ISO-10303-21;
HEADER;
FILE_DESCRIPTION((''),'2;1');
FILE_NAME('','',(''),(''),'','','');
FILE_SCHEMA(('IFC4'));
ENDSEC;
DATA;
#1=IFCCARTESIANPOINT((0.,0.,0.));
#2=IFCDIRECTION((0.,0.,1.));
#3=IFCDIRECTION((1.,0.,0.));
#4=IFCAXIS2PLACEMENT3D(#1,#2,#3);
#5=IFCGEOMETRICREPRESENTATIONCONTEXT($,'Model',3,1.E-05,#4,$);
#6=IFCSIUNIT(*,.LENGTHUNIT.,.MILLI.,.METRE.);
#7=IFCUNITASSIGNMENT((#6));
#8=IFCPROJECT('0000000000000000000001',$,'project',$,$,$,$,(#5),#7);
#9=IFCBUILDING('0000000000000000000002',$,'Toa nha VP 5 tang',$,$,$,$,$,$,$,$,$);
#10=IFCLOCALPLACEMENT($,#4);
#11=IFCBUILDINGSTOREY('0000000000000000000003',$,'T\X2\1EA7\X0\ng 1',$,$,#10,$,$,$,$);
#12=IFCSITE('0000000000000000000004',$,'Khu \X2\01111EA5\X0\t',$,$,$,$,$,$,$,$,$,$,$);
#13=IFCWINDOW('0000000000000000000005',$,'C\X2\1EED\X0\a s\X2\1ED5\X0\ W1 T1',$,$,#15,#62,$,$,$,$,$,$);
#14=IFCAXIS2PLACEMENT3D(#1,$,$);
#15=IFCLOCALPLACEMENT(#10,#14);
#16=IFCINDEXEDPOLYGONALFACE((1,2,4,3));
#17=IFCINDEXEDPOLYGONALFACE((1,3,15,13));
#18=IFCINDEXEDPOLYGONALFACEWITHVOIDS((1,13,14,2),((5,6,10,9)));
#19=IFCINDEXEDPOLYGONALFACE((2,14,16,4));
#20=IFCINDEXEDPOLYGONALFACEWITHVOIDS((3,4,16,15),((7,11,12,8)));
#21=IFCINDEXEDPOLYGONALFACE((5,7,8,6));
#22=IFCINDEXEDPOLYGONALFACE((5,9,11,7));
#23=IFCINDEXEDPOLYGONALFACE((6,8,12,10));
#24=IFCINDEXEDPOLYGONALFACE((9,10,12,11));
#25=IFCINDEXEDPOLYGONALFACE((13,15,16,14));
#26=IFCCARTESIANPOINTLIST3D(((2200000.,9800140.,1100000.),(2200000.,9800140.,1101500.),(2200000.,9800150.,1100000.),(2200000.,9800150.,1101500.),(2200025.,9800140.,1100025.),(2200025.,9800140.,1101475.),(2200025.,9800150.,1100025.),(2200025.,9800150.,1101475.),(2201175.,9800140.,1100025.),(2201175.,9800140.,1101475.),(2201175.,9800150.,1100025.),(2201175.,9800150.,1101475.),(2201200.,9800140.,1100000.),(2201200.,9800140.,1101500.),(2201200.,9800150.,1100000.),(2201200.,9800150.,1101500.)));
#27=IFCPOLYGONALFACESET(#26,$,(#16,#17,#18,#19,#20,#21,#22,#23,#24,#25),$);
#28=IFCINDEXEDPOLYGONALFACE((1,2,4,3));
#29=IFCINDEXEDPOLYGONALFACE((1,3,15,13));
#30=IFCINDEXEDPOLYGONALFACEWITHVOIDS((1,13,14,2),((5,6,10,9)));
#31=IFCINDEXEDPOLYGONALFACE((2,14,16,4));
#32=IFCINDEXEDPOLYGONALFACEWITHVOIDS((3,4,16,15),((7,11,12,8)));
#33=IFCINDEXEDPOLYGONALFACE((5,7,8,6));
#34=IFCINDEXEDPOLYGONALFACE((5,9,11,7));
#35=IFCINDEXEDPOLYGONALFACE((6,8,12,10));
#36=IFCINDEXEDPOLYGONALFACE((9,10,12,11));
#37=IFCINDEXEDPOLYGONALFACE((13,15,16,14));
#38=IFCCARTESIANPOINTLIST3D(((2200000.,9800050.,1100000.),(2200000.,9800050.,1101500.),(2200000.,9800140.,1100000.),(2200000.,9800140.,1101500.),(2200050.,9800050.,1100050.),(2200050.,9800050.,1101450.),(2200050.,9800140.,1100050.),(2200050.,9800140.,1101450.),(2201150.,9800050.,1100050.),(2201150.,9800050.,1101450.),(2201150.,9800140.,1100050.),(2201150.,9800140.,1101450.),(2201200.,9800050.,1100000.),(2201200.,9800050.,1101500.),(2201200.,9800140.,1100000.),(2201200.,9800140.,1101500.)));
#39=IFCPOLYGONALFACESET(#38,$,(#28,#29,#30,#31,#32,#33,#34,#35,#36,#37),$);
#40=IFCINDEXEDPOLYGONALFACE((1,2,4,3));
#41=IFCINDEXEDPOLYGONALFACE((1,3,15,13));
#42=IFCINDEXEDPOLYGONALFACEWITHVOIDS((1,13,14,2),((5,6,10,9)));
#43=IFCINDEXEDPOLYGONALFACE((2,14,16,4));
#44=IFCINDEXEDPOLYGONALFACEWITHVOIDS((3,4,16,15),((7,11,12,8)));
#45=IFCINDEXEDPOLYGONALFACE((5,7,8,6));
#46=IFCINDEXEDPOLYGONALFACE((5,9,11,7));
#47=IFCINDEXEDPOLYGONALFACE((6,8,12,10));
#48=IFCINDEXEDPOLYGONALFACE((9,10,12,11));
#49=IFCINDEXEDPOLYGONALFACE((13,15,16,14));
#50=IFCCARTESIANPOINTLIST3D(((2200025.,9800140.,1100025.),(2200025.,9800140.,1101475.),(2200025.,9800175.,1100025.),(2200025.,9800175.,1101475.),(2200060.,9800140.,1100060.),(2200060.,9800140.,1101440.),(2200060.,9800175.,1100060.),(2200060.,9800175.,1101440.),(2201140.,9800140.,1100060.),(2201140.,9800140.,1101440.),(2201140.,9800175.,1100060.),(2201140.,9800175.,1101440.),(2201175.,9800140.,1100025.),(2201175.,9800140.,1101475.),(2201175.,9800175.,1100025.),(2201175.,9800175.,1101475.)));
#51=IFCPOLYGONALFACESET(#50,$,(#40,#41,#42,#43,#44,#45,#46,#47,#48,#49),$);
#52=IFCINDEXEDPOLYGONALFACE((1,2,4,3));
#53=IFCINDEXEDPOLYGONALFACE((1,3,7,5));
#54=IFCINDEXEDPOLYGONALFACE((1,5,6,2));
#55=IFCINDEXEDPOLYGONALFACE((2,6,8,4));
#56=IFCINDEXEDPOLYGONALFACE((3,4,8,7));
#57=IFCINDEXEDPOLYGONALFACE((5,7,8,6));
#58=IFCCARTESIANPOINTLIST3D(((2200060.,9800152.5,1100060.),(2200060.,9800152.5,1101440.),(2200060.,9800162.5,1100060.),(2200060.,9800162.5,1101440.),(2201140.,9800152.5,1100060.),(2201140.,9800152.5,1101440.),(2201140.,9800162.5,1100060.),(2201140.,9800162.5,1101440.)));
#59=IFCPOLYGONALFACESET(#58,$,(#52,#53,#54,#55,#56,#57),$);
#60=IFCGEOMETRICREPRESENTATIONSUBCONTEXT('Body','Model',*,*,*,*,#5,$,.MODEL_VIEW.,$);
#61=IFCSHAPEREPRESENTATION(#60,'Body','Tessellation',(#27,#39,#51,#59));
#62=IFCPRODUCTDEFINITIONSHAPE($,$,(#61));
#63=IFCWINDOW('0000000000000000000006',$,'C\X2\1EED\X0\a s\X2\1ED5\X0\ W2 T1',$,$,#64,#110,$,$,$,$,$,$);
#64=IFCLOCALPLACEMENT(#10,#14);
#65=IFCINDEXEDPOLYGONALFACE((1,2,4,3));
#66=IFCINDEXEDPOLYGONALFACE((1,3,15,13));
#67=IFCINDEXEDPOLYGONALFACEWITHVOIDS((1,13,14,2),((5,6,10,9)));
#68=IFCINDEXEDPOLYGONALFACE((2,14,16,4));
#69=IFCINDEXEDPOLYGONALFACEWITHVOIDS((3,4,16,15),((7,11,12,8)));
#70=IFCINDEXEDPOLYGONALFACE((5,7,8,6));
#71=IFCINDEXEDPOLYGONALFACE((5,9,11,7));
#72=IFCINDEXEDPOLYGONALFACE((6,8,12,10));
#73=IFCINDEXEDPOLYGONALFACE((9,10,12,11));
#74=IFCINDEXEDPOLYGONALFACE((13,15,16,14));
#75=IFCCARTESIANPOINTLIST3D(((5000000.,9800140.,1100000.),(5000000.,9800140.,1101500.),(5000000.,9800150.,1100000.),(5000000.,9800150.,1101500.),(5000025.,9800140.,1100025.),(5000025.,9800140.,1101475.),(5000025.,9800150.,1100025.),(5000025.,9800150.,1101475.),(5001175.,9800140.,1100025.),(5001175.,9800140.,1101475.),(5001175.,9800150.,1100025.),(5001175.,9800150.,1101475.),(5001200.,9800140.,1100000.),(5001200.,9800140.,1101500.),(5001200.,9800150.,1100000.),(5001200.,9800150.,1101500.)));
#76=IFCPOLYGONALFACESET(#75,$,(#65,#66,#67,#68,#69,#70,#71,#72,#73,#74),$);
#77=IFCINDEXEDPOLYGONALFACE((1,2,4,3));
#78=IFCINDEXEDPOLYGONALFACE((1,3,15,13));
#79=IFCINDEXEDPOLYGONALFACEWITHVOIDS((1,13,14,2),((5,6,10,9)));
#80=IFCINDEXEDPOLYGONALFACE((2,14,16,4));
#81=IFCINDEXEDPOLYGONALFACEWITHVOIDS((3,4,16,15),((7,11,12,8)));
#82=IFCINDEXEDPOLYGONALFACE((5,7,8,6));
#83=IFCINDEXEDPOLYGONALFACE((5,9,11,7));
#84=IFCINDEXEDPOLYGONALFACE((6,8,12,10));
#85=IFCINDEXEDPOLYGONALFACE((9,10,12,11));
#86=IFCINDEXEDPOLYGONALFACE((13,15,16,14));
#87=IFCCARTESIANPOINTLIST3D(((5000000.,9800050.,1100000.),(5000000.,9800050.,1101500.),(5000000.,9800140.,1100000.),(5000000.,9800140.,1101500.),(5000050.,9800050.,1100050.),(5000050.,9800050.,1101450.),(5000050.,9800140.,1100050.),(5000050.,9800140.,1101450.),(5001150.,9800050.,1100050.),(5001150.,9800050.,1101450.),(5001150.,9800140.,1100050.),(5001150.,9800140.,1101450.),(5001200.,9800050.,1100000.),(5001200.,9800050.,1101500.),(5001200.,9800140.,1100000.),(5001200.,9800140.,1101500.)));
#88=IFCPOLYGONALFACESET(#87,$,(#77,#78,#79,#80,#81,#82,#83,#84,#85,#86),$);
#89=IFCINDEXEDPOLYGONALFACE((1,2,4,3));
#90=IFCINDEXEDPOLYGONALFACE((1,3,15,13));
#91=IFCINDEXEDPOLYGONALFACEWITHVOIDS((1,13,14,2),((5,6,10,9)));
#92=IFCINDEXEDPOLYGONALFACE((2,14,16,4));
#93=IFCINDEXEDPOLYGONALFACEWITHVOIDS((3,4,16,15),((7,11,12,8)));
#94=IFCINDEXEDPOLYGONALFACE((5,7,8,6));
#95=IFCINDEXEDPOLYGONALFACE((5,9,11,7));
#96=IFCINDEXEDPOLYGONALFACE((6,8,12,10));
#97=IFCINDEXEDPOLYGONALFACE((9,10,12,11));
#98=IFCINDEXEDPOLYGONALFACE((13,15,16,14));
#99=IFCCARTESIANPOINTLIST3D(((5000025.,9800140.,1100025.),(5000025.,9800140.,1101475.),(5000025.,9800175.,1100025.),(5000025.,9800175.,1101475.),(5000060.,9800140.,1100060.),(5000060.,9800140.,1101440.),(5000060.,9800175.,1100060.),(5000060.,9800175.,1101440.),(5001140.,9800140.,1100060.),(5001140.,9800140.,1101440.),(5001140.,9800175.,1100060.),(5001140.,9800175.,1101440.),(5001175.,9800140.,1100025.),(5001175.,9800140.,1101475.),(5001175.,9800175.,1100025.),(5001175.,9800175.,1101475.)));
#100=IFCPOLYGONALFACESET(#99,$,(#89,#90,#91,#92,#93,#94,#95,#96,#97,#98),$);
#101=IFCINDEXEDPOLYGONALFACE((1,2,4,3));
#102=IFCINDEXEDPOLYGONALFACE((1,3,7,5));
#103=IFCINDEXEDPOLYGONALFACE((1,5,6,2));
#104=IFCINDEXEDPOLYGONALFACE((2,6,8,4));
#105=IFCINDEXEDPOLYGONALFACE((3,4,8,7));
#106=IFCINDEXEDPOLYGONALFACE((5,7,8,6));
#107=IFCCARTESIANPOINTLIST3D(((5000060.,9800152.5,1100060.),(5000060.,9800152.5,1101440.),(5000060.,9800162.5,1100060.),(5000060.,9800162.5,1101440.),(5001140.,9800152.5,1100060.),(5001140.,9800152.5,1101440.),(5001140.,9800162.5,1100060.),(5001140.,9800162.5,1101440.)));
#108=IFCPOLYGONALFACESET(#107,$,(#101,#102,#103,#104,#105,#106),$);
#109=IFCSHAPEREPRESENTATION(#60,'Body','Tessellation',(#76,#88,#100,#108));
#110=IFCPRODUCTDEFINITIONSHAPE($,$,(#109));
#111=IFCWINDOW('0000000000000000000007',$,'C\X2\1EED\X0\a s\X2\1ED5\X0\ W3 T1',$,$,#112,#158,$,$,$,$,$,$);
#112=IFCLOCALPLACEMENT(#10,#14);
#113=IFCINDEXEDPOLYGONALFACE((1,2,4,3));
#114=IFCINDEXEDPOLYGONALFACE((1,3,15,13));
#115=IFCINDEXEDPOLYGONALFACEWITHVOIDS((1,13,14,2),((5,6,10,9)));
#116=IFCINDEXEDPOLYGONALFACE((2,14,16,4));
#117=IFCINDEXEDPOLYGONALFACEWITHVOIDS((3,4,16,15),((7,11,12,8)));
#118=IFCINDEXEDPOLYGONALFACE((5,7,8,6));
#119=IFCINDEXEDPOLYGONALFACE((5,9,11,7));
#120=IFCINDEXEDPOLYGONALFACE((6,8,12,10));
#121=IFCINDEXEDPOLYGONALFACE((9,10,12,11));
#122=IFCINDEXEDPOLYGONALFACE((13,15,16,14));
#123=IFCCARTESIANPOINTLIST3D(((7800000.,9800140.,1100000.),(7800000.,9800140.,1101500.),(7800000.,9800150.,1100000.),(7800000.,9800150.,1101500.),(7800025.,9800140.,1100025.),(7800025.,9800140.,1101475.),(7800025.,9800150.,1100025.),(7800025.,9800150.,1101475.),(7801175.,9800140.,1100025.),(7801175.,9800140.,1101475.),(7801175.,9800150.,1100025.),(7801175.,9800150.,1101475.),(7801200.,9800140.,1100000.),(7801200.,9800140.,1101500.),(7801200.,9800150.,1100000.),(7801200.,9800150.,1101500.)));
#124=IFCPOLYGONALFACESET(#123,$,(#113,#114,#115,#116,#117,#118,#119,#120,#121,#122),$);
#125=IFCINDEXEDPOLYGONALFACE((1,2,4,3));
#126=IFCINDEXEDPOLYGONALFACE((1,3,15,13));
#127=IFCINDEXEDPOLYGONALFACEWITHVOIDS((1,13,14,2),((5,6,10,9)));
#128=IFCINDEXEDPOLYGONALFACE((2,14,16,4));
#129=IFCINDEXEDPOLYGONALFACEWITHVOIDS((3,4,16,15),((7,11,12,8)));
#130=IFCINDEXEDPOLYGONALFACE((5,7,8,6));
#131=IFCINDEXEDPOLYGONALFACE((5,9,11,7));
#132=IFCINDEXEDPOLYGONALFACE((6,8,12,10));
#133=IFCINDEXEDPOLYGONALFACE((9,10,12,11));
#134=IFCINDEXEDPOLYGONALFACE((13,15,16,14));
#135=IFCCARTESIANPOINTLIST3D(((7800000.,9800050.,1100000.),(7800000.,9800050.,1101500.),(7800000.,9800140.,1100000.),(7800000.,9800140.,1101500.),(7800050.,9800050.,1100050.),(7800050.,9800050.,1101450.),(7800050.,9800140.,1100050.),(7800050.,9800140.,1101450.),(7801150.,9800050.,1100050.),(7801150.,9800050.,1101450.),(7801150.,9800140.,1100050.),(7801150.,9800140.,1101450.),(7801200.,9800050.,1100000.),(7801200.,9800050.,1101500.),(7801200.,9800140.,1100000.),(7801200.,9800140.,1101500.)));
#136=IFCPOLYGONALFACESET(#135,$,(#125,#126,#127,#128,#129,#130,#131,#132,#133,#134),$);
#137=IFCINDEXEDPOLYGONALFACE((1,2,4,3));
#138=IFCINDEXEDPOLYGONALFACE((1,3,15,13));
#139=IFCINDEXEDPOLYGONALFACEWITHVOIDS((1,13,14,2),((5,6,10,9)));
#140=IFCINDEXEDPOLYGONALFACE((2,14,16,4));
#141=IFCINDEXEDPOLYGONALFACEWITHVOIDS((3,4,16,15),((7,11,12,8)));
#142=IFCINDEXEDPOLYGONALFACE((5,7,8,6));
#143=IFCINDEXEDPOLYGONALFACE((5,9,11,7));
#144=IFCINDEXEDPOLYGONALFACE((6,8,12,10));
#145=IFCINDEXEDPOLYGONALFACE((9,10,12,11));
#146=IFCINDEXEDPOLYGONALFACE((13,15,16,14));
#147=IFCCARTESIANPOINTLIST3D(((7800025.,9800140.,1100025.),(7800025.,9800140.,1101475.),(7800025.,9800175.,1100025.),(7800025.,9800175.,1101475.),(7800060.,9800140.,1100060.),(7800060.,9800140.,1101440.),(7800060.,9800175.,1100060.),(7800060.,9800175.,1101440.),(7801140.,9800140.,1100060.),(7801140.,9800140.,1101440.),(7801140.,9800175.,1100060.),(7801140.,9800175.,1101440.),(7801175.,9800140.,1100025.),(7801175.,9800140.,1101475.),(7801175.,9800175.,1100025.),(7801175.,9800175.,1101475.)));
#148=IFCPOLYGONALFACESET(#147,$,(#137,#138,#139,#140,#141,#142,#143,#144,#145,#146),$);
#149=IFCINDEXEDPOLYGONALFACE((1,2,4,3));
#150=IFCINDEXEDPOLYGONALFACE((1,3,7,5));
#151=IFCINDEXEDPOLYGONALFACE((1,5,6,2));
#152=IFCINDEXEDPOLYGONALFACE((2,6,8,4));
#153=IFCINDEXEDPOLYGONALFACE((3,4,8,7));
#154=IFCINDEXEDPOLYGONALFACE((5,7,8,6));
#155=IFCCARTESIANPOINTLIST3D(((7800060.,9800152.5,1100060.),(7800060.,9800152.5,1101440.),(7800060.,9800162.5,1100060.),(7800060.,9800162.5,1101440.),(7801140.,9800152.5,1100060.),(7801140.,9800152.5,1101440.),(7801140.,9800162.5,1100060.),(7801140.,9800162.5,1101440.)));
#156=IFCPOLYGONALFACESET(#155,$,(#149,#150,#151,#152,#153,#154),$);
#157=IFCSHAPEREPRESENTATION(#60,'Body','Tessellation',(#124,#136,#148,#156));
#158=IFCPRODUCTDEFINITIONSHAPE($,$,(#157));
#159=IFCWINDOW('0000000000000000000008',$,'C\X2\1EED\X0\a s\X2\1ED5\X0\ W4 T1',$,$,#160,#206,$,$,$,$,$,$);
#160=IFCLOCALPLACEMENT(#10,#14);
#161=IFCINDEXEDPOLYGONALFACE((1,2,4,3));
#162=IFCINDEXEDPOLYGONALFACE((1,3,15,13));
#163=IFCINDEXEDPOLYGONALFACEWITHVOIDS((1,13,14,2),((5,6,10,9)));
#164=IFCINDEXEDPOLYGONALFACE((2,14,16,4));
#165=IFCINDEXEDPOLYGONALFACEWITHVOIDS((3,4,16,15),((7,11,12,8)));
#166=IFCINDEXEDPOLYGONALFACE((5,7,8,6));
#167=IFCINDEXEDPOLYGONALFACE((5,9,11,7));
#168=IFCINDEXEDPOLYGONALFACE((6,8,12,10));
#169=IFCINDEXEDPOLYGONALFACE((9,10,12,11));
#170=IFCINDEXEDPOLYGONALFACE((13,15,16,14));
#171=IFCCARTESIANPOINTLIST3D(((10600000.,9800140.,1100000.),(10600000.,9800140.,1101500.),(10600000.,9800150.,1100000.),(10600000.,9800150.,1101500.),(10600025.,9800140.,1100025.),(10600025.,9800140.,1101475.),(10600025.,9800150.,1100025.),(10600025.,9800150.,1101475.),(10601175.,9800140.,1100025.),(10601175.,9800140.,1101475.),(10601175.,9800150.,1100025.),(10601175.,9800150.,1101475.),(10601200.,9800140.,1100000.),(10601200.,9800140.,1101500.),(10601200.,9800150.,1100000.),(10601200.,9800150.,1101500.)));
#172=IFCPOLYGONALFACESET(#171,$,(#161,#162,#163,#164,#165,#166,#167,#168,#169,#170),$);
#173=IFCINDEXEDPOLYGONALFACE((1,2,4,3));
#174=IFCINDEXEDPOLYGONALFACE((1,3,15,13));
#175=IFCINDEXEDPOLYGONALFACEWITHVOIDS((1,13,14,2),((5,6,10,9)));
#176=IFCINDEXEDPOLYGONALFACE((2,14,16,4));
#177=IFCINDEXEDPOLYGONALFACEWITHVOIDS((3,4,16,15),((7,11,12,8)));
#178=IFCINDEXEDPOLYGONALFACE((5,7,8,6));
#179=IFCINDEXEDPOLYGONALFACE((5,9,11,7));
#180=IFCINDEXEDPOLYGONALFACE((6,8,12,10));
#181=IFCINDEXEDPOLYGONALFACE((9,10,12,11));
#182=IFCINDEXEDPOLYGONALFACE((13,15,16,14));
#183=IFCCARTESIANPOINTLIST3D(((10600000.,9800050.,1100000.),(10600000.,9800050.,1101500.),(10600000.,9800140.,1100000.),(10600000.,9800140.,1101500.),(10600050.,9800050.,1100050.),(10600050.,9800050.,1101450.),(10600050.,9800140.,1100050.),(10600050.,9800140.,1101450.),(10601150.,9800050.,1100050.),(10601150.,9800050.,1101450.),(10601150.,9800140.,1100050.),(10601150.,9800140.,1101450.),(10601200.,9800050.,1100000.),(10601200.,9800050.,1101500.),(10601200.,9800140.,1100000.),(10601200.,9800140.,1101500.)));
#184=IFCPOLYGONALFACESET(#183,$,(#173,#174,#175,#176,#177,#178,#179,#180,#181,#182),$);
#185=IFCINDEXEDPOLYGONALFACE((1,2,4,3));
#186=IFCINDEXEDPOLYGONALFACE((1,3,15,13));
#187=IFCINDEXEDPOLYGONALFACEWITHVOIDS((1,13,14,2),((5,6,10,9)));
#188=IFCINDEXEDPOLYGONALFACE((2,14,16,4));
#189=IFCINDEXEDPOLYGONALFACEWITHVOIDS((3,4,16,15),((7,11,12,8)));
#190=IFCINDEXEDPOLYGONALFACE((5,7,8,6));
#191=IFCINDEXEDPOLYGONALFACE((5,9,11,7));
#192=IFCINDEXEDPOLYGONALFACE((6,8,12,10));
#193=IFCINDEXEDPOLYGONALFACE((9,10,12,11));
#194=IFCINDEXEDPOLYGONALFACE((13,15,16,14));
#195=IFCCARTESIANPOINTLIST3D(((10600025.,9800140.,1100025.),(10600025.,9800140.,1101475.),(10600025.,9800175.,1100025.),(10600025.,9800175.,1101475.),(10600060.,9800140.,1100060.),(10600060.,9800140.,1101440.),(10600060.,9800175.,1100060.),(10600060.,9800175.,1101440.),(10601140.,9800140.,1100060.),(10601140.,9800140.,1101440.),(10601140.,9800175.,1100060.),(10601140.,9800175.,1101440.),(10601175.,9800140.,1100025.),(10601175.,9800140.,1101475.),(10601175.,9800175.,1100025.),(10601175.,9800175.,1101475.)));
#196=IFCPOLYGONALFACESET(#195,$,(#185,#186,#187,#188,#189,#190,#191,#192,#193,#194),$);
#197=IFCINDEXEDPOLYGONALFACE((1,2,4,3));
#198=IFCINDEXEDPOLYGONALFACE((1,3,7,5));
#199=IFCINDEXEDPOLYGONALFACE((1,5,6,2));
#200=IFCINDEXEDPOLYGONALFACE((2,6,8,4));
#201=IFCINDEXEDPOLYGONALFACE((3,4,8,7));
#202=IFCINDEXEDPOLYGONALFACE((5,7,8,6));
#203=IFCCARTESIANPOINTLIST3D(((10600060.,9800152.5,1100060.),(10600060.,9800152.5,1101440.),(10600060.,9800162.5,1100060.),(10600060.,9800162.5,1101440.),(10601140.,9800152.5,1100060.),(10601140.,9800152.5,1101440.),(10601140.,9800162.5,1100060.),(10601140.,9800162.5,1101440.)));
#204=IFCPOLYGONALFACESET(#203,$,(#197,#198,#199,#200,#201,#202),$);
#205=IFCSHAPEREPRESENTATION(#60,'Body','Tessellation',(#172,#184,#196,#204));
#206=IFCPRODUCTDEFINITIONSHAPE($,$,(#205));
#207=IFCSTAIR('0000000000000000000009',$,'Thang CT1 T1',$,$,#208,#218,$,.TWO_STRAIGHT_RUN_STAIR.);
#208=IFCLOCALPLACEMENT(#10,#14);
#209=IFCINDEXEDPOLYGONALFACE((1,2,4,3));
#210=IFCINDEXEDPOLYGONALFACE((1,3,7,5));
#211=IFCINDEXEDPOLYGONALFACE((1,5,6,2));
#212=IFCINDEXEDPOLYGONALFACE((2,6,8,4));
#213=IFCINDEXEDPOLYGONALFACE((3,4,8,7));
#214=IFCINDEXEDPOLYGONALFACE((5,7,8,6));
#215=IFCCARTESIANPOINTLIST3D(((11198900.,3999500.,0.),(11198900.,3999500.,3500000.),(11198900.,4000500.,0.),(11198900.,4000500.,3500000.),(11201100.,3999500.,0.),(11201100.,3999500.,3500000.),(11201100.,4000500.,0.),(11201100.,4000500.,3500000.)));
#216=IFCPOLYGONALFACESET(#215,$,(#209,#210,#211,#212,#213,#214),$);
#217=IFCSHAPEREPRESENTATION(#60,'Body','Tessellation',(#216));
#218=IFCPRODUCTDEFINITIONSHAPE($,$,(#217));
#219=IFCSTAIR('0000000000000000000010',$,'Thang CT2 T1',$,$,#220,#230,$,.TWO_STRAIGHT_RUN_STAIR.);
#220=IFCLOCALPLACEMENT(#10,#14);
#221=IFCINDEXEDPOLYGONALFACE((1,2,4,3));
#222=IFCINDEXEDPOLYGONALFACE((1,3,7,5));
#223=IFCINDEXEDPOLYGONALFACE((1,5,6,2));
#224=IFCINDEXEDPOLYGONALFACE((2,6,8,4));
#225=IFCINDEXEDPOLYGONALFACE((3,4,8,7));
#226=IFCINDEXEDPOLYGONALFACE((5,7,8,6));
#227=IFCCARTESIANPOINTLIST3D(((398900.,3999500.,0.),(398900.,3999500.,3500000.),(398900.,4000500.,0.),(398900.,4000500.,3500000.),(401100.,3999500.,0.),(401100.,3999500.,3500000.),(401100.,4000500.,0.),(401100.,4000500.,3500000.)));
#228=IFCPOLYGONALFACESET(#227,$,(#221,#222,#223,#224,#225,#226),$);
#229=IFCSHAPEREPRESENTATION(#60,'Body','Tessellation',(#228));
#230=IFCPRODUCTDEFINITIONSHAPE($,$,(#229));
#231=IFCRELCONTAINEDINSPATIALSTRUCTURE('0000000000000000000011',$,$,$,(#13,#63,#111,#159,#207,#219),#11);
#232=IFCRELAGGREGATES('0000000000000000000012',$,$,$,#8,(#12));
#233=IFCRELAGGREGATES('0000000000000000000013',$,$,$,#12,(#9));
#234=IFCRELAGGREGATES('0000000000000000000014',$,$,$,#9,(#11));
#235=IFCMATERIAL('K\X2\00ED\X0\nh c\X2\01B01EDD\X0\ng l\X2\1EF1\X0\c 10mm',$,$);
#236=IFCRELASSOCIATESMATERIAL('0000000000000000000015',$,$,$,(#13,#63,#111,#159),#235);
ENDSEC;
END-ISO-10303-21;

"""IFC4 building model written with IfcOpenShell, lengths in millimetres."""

from ifc_helpers import new_model, entity, si_unit, frame, origin_with_axes, place, context, subcontext, project, spatial, line, indexed_curve, outline, extrude, material, element, save


model = new_model("IFC4")

# Units and contexts
model_context = context("Model", 3, precision=1e-05, world=origin_with_axes())
body_context = subcontext(model_context, "Body", "Model", "MODEL_VIEW")
ifc_project = project(units=[si_unit("LENGTHUNIT", "METRE", prefix="MILLI")], contexts=[model_context])

# Site, building, storey
site = spatial("IfcSite", under=ifc_project, Name="Khu đất")
building = spatial("IfcBuilding", under=site, Name="Toa nha VP 5 tang")
storey_placement = place(None, origin_with_axes())
storey = spatial("IfcBuildingStorey", under=building, at=storey_placement, Name="Tầng 1")

# Windows
ifc_material_1 = material(Name="Kính cường lực 10mm")
for number, where, z_axis, x_axis, name in (
    (1, (2200000.0, 9800000.0, 1100000.0), (0.0, 0.0, 1.0), (1.0, 0.0, 0.0), "Cửa sổ W1 T1"),
    (2, (5000000.0, 9800000.0, 1100000.0), (0.0, 0.0, 1.0), (1.0, 0.0, 0.0), "Cửa sổ W2 T1"),
    (3, (7800000.0, 9800000.0, 1100000.0), (0.0, 0.0, 1.0), (1.0, 0.0, 0.0), "Cửa sổ W3 T1"),
    (4, (10600000.0, 9800000.0, 1100000.0), (0.0, 0.0, 1.0), (1.0, 0.0, 0.0), "Cửa sổ W4 T1"),
):
    element("IfcWindow", number, at=place(storey_placement, frame(where, z_axis=z_axis, x_axis=x_axis)), inside=storey, material=ifc_material_1, Name=name, context=body_context, shape_type="SolidModel", body=[
        extrude(outline(indexed_curve([(0.0, 0.0), (1200.0, 0.0), (1200.0, 1500.0), (0.0, 1500.0)], segments=[line(1, 2, 3, 4, 1)]), holes=[indexed_curve([(25.0, 25.0), (1175.0, 25.0), (1175.0, 1475.0), (25.0, 1475.0)], segments=[line(1, 2, 3, 4, 1)])]), frame((0.0, 140.0, 0.0), z_axis=(0.0, -1.0, 0.0), x_axis=(1.0, 0.0, 0.0)), (0.0, 0.0, -1.0), 10.0),
        extrude(outline(indexed_curve([(0.0, 0.0), (1200.0, 0.0), (1200.0, 1500.0), (0.0, 1500.0)], segments=[line(1, 2, 3, 4, 1)]), holes=[indexed_curve([(50.0, 50.0), (1150.0, 50.0), (1150.0, 1450.0), (50.0, 1450.0)], segments=[line(1, 2, 3, 4, 1)])]), frame((0.0, 50.0, 0.0), z_axis=(0.0, -1.0, 0.0), x_axis=(1.0, 0.0, 0.0)), (0.0, 0.0, -1.0), 90.0),
        extrude(outline(indexed_curve([(0.0, 0.0), (1150.0, 0.0), (1150.0, 1450.0), (0.0, 1450.0)], segments=[line(1, 2, 3, 4, 1)]), holes=[indexed_curve([(35.0, 35.0), (1115.0, 35.0), (1115.0, 1415.0), (35.0, 1415.0)], segments=[line(1, 2, 3, 4, 1)])]), frame((25.0, 140.0, 25.0), z_axis=(0.0, -1.0, 0.0), x_axis=(1.0, 0.0, 0.0)), (0.0, 0.0, -1.0), 35.0),
        extrude(outline(indexed_curve([(35.0, 35.0), (1115.0, 35.0), (1115.0, 1415.0), (35.0, 1415.0)], segments=[line(1, 2, 3, 4, 1)])), frame((25.0, 152.5, 25.0), z_axis=(0.0, -1.0, 0.0), x_axis=(1.0, 0.0, 0.0)), (0.0, 0.0, -1.0), 10.0),
    ])

# Stairs
for number, where, z_axis, x_axis, name in (
    (5, (11200000.0, 4000000.0, 0.0), (0.0, 0.0, 1.0), (1.0, 0.0, 0.0), "Thang CT1 T1"),
    (6, (400000.0, 4000000.0, 0.0), (0.0, 0.0, 1.0), (1.0, 0.0, 0.0), "Thang CT2 T1"),
):
    element("IfcStair", number, at=place(storey_placement, frame(where, z_axis=z_axis, x_axis=x_axis)), inside=storey, Name=name, PredefinedType="TWO_STRAIGHT_RUN_STAIR", context=body_context, shape_type="SweptSolid", body=[
        extrude(entity("IfcRectangleProfileDef", None, None, None, 2200.0, 1000.0), origin_with_axes(), (0.0, 0.0, 1.0), 3500000.0),
    ])

save(model, "model.ifc")
